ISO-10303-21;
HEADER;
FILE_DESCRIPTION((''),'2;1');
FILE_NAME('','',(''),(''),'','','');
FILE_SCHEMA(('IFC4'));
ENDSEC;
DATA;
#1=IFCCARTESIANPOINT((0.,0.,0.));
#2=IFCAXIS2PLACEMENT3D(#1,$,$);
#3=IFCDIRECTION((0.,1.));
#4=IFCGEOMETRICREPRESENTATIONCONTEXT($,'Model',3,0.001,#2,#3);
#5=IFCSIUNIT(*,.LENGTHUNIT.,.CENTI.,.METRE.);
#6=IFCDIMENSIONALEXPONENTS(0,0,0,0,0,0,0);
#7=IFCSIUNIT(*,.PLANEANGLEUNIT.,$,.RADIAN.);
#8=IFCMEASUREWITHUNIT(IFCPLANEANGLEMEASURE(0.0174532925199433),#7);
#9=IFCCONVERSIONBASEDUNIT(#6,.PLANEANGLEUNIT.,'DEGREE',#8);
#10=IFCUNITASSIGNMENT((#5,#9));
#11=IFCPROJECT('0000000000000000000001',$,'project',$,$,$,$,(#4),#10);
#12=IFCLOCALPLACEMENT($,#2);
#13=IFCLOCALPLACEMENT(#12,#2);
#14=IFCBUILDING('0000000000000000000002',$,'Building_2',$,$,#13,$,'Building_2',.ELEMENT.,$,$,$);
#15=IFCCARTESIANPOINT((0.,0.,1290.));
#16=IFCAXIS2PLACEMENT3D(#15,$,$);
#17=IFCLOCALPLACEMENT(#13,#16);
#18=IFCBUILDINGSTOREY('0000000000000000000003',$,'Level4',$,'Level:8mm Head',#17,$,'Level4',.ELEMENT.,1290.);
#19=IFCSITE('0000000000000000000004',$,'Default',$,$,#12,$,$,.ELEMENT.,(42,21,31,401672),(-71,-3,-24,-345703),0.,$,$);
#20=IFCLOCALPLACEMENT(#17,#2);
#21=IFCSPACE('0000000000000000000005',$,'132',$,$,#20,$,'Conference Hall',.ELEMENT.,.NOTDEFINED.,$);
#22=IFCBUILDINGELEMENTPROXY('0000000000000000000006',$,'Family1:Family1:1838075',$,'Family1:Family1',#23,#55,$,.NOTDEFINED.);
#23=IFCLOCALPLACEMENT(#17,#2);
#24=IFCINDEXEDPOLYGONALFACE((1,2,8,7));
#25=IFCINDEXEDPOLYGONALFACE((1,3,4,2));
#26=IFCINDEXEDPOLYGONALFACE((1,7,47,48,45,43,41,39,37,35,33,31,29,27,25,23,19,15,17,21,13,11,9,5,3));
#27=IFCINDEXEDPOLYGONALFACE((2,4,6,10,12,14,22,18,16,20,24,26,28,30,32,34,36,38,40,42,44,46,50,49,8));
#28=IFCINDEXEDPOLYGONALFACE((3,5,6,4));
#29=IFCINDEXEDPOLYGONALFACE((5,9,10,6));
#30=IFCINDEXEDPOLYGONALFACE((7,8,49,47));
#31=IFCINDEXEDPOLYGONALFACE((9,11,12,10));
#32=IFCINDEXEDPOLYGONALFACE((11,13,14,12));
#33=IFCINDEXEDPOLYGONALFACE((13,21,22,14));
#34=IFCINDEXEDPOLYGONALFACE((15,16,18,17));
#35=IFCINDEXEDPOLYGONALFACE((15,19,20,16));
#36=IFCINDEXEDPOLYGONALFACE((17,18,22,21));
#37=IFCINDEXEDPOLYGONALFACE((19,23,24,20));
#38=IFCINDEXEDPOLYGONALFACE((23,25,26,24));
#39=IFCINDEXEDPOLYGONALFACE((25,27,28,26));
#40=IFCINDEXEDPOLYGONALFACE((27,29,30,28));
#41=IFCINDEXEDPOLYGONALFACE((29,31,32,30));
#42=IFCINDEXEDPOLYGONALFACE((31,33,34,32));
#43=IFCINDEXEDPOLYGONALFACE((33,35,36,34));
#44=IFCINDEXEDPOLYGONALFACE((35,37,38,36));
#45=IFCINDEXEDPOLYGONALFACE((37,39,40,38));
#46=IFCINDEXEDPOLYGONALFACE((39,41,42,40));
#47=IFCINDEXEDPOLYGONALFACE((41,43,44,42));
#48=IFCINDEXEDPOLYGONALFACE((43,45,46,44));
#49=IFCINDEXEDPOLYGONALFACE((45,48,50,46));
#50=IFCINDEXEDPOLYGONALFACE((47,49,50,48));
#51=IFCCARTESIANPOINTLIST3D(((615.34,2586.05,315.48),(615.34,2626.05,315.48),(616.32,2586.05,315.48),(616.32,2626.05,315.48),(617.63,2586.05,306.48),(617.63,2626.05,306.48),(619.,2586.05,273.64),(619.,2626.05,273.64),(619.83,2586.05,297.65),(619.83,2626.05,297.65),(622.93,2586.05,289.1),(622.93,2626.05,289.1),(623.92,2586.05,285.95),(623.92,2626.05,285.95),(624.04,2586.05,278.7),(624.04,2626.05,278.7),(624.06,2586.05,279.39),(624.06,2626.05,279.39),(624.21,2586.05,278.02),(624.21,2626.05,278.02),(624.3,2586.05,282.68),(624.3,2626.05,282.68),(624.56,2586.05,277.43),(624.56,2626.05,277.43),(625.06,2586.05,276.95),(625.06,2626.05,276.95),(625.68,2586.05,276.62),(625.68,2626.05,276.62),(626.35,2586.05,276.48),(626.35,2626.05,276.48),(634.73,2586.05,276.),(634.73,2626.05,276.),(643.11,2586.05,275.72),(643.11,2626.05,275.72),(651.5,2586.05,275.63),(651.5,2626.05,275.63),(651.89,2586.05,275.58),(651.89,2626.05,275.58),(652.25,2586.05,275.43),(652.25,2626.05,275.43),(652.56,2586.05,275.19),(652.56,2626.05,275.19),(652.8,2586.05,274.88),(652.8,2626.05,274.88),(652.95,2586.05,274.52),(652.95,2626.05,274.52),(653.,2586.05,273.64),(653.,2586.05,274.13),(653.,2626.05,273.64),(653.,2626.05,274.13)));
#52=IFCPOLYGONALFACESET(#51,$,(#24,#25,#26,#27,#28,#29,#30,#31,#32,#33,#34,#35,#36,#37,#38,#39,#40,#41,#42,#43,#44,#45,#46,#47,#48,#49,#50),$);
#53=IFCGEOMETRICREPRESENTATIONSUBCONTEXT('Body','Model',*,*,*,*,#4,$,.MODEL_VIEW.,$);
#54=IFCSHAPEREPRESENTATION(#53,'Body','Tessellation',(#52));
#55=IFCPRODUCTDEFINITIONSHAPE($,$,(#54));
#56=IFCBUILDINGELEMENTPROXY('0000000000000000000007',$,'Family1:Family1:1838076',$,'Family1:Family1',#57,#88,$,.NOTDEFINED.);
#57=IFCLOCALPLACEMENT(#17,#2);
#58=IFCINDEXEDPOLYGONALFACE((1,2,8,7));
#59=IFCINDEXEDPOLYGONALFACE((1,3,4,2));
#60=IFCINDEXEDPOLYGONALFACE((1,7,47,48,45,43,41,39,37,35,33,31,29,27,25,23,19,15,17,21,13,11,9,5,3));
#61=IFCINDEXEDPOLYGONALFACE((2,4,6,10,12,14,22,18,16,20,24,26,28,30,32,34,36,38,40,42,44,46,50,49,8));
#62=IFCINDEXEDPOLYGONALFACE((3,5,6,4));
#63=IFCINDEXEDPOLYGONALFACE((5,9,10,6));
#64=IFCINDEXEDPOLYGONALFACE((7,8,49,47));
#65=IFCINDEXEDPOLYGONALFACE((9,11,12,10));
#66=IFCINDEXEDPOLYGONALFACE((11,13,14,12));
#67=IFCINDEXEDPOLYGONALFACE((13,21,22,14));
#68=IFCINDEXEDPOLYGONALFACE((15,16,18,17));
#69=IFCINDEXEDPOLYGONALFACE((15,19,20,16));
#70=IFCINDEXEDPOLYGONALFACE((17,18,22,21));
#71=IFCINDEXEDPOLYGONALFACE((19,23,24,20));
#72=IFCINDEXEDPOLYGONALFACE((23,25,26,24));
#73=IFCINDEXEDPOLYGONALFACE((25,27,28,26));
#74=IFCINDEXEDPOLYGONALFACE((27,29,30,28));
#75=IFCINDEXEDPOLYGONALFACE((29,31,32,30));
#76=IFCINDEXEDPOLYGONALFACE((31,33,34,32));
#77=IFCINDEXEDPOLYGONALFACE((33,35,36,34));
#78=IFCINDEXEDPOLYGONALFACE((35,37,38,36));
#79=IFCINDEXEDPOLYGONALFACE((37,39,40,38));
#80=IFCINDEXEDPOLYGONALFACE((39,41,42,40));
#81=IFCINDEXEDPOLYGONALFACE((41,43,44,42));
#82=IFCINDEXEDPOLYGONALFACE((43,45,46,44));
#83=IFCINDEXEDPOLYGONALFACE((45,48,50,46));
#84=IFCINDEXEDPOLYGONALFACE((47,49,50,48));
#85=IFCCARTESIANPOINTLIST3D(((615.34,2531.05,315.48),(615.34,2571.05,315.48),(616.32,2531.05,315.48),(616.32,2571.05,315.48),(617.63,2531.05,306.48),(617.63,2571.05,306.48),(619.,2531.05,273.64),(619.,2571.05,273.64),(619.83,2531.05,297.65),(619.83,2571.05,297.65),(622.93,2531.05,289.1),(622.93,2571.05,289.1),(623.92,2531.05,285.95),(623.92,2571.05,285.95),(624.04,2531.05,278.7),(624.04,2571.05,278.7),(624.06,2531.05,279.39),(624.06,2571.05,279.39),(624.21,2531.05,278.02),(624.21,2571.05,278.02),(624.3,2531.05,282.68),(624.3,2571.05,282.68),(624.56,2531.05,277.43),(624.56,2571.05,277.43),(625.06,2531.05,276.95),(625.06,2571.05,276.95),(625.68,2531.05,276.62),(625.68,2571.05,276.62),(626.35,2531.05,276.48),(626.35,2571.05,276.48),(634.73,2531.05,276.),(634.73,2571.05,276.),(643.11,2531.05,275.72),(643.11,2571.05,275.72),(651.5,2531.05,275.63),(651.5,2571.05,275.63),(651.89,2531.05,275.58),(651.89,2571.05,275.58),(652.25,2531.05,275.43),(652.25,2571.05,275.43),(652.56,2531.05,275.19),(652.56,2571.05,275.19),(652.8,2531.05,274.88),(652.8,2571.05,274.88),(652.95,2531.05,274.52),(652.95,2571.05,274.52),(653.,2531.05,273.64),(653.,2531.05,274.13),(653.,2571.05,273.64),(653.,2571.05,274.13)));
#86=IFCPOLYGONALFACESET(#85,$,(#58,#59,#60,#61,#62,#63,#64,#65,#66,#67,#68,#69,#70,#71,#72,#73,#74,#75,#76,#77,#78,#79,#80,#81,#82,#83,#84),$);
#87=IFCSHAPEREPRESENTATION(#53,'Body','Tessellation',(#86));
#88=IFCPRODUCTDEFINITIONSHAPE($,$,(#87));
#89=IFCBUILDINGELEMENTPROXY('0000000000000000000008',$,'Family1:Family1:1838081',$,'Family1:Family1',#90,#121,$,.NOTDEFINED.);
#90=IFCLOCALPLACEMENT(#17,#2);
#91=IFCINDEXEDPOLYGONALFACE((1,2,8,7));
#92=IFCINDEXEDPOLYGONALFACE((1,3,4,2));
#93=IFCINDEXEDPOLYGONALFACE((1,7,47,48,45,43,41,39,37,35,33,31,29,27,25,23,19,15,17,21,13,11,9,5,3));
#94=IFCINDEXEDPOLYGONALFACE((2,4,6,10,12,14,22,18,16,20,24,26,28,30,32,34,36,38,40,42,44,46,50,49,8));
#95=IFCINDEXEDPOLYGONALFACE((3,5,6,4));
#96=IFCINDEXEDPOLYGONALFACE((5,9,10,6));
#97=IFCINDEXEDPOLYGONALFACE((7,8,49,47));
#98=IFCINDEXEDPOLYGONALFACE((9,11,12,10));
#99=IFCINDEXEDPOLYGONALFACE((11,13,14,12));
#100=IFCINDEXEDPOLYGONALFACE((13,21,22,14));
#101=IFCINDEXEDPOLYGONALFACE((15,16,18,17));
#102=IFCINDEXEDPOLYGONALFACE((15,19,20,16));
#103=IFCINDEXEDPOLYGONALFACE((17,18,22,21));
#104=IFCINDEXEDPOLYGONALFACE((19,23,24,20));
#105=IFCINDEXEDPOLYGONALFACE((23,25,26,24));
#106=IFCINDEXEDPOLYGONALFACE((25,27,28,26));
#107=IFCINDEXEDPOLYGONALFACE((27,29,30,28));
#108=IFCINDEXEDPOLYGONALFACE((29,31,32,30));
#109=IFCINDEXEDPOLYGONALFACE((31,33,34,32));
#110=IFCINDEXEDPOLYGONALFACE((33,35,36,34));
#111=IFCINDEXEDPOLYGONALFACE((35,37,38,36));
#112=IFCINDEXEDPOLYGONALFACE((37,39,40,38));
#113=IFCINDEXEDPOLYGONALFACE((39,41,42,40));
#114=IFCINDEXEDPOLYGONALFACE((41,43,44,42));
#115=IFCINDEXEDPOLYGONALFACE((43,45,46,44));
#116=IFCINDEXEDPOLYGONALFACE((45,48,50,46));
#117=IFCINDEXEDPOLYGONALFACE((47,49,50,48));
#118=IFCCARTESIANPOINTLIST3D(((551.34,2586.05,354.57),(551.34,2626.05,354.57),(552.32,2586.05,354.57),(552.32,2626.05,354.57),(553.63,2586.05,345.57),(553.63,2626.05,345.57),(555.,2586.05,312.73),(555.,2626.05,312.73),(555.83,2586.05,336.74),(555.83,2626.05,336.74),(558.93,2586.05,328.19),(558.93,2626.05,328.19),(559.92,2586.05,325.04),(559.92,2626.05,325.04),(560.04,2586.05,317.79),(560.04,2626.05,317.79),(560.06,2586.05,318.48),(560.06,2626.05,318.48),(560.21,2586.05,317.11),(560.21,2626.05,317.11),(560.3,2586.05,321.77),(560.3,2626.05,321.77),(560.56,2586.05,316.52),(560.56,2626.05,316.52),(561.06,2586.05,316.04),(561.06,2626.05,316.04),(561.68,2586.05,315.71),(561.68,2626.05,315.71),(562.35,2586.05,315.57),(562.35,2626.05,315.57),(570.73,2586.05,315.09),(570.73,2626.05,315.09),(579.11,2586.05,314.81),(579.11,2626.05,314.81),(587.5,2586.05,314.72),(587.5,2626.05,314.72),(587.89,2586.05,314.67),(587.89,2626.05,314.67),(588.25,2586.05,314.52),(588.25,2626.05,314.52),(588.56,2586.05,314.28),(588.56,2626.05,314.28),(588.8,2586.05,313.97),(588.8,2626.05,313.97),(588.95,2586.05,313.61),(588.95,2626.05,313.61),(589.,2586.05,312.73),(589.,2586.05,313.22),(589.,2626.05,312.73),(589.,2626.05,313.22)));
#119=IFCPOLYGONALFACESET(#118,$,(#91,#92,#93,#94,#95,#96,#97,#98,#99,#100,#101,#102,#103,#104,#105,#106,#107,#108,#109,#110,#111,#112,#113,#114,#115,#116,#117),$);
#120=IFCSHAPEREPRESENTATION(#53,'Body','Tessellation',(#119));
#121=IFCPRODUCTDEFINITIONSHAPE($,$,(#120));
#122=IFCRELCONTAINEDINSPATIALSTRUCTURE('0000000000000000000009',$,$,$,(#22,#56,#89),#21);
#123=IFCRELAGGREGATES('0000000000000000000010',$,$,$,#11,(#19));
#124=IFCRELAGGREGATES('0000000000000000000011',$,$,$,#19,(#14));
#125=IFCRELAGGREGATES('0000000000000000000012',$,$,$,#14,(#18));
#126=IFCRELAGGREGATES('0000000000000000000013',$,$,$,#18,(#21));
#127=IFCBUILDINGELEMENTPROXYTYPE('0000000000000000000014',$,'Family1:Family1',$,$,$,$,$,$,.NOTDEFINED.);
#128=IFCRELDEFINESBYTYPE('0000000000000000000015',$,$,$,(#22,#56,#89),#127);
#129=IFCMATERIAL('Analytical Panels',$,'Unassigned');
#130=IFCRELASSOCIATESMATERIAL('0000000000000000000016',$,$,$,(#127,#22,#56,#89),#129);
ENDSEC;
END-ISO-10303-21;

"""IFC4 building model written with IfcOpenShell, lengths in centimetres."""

from ifc_helpers import new_model, entity, si_unit, converted_unit, direction, frame, origin, place, context, subcontext, project, spatial, line, arc, indexed_curve, outline, extrude, source, transform, mapped, material, type_object, type_shapes, element, save


model = new_model("IFC4")

# Units and contexts
model_context = context("Model", 3, precision=0.001, world=origin(), true_north=direction((0.0, 1.0)))
body_context = subcontext(model_context, "Body", "Model", "MODEL_VIEW")
ifc_project = project(units=[si_unit("LENGTHUNIT", "METRE", prefix="CENTI"), converted_unit("PLANEANGLEUNIT", "DEGREE", entity("IfcPlaneAngleMeasure", 0.0174532925199433), si_unit("PLANEANGLEUNIT", "RADIAN"), dimensions=[0, 0, 0, 0, 0, 0, 0])], contexts=[model_context])

# Site, building, storey
site_placement = place(None, origin())
site = spatial("IfcSite", under=ifc_project, at=site_placement, Name="Default", CompositionType="ELEMENT", RefLatitude=(42, 21, 31, 401672), RefLongitude=(-71, -3, -24, -345703), RefElevation=0.0)
building_placement = place(site_placement, origin())
building = spatial("IfcBuilding", under=site, at=building_placement, Name="Building_2", LongName="Building_2", CompositionType="ELEMENT")
storey_placement = place(building_placement, frame((0.0, 0.0, 1290.0)))
storey = spatial("IfcBuildingStorey", under=building, at=storey_placement, Name="Level4", ObjectType="Level:8mm Head", LongName="Level4", CompositionType="ELEMENT", Elevation=1290.0)

# Shared definitions
space_1_placement = place(storey_placement, origin())
space_1 = spatial("IfcSpace", under=storey, at=space_1_placement, Name="132", LongName="Conference Hall", CompositionType="ELEMENT", PredefinedType="NOTDEFINED")

# Building element proxies
ifc_material_1 = material(Name="Analytical Panels", Category="Unassigned")
building_element_proxy_type_1 = type_object("IfcBuildingElementProxyType", Name="Family1:Family1", PredefinedType="NOTDEFINED", material=ifc_material_1)
shared_shape_1 = source(origin(), body_context, "Body", "SweptSolid", [
    extrude(outline(indexed_curve([(-11.13, -13.3), (30.87, -13.3), (30.78, -12.32), (17.19, -11.21), (3.93, -8.04), (-0.94, -7.2), (-5.84, -7.76), (-7.84, -7.43), (-8.94, -5.73), (-10.68, 6.74), (-11.98, 19.25), (-12.51, 20.27), (-13.6, 20.61), (-14.09, 20.57)], segments=[line(1, 2, 3), arc(3, 4, 5), arc(5, 6, 7), arc(7, 8, 9), arc(9, 10, 11), arc(11, 12, 13), line(13, 14, 1)], self_intersect=False)), frame((-20.0, 6.72, 12.25), z_axis=(1.0, 0.0, 0.0), x_axis=(0.0, 0.087156, 0.996195)), (0.0, 0.0, 1.0), 40.0),
])
type_shapes(building_element_proxy_type_1, [shared_shape_1])
for number, where, z_axis, x_axis, name in (
    (1, (638.0, 2606.05, 273.64), (0.0, 0.0, 1.0), (0.0, 1.0, 0.0), "Family1:Family1:1838075"),
    (2, (638.0, 2551.05, 273.64), (0.0, 0.0, 1.0), (0.0, 1.0, 0.0), "Family1:Family1:1838076"),
    (3, (574.0, 2606.05, 312.73), (0.0, 0.0, 1.0), (0.0, 1.0, 0.0), "Family1:Family1:1838081"),
):
    element("IfcBuildingElementProxy", number, at=place(space_1_placement, frame(where, z_axis=z_axis, x_axis=x_axis)), inside=space_1, type_object=building_element_proxy_type_1, material=ifc_material_1, Name=name, ObjectType="Family1:Family1", PredefinedType="NOTDEFINED", context=body_context, shape_type="MappedRepresentation", body=[
        mapped(shared_shape_1, transform((0.0, 0.0, 0.0), scale=1.0)),
    ])

save(model, "model.ifc")
